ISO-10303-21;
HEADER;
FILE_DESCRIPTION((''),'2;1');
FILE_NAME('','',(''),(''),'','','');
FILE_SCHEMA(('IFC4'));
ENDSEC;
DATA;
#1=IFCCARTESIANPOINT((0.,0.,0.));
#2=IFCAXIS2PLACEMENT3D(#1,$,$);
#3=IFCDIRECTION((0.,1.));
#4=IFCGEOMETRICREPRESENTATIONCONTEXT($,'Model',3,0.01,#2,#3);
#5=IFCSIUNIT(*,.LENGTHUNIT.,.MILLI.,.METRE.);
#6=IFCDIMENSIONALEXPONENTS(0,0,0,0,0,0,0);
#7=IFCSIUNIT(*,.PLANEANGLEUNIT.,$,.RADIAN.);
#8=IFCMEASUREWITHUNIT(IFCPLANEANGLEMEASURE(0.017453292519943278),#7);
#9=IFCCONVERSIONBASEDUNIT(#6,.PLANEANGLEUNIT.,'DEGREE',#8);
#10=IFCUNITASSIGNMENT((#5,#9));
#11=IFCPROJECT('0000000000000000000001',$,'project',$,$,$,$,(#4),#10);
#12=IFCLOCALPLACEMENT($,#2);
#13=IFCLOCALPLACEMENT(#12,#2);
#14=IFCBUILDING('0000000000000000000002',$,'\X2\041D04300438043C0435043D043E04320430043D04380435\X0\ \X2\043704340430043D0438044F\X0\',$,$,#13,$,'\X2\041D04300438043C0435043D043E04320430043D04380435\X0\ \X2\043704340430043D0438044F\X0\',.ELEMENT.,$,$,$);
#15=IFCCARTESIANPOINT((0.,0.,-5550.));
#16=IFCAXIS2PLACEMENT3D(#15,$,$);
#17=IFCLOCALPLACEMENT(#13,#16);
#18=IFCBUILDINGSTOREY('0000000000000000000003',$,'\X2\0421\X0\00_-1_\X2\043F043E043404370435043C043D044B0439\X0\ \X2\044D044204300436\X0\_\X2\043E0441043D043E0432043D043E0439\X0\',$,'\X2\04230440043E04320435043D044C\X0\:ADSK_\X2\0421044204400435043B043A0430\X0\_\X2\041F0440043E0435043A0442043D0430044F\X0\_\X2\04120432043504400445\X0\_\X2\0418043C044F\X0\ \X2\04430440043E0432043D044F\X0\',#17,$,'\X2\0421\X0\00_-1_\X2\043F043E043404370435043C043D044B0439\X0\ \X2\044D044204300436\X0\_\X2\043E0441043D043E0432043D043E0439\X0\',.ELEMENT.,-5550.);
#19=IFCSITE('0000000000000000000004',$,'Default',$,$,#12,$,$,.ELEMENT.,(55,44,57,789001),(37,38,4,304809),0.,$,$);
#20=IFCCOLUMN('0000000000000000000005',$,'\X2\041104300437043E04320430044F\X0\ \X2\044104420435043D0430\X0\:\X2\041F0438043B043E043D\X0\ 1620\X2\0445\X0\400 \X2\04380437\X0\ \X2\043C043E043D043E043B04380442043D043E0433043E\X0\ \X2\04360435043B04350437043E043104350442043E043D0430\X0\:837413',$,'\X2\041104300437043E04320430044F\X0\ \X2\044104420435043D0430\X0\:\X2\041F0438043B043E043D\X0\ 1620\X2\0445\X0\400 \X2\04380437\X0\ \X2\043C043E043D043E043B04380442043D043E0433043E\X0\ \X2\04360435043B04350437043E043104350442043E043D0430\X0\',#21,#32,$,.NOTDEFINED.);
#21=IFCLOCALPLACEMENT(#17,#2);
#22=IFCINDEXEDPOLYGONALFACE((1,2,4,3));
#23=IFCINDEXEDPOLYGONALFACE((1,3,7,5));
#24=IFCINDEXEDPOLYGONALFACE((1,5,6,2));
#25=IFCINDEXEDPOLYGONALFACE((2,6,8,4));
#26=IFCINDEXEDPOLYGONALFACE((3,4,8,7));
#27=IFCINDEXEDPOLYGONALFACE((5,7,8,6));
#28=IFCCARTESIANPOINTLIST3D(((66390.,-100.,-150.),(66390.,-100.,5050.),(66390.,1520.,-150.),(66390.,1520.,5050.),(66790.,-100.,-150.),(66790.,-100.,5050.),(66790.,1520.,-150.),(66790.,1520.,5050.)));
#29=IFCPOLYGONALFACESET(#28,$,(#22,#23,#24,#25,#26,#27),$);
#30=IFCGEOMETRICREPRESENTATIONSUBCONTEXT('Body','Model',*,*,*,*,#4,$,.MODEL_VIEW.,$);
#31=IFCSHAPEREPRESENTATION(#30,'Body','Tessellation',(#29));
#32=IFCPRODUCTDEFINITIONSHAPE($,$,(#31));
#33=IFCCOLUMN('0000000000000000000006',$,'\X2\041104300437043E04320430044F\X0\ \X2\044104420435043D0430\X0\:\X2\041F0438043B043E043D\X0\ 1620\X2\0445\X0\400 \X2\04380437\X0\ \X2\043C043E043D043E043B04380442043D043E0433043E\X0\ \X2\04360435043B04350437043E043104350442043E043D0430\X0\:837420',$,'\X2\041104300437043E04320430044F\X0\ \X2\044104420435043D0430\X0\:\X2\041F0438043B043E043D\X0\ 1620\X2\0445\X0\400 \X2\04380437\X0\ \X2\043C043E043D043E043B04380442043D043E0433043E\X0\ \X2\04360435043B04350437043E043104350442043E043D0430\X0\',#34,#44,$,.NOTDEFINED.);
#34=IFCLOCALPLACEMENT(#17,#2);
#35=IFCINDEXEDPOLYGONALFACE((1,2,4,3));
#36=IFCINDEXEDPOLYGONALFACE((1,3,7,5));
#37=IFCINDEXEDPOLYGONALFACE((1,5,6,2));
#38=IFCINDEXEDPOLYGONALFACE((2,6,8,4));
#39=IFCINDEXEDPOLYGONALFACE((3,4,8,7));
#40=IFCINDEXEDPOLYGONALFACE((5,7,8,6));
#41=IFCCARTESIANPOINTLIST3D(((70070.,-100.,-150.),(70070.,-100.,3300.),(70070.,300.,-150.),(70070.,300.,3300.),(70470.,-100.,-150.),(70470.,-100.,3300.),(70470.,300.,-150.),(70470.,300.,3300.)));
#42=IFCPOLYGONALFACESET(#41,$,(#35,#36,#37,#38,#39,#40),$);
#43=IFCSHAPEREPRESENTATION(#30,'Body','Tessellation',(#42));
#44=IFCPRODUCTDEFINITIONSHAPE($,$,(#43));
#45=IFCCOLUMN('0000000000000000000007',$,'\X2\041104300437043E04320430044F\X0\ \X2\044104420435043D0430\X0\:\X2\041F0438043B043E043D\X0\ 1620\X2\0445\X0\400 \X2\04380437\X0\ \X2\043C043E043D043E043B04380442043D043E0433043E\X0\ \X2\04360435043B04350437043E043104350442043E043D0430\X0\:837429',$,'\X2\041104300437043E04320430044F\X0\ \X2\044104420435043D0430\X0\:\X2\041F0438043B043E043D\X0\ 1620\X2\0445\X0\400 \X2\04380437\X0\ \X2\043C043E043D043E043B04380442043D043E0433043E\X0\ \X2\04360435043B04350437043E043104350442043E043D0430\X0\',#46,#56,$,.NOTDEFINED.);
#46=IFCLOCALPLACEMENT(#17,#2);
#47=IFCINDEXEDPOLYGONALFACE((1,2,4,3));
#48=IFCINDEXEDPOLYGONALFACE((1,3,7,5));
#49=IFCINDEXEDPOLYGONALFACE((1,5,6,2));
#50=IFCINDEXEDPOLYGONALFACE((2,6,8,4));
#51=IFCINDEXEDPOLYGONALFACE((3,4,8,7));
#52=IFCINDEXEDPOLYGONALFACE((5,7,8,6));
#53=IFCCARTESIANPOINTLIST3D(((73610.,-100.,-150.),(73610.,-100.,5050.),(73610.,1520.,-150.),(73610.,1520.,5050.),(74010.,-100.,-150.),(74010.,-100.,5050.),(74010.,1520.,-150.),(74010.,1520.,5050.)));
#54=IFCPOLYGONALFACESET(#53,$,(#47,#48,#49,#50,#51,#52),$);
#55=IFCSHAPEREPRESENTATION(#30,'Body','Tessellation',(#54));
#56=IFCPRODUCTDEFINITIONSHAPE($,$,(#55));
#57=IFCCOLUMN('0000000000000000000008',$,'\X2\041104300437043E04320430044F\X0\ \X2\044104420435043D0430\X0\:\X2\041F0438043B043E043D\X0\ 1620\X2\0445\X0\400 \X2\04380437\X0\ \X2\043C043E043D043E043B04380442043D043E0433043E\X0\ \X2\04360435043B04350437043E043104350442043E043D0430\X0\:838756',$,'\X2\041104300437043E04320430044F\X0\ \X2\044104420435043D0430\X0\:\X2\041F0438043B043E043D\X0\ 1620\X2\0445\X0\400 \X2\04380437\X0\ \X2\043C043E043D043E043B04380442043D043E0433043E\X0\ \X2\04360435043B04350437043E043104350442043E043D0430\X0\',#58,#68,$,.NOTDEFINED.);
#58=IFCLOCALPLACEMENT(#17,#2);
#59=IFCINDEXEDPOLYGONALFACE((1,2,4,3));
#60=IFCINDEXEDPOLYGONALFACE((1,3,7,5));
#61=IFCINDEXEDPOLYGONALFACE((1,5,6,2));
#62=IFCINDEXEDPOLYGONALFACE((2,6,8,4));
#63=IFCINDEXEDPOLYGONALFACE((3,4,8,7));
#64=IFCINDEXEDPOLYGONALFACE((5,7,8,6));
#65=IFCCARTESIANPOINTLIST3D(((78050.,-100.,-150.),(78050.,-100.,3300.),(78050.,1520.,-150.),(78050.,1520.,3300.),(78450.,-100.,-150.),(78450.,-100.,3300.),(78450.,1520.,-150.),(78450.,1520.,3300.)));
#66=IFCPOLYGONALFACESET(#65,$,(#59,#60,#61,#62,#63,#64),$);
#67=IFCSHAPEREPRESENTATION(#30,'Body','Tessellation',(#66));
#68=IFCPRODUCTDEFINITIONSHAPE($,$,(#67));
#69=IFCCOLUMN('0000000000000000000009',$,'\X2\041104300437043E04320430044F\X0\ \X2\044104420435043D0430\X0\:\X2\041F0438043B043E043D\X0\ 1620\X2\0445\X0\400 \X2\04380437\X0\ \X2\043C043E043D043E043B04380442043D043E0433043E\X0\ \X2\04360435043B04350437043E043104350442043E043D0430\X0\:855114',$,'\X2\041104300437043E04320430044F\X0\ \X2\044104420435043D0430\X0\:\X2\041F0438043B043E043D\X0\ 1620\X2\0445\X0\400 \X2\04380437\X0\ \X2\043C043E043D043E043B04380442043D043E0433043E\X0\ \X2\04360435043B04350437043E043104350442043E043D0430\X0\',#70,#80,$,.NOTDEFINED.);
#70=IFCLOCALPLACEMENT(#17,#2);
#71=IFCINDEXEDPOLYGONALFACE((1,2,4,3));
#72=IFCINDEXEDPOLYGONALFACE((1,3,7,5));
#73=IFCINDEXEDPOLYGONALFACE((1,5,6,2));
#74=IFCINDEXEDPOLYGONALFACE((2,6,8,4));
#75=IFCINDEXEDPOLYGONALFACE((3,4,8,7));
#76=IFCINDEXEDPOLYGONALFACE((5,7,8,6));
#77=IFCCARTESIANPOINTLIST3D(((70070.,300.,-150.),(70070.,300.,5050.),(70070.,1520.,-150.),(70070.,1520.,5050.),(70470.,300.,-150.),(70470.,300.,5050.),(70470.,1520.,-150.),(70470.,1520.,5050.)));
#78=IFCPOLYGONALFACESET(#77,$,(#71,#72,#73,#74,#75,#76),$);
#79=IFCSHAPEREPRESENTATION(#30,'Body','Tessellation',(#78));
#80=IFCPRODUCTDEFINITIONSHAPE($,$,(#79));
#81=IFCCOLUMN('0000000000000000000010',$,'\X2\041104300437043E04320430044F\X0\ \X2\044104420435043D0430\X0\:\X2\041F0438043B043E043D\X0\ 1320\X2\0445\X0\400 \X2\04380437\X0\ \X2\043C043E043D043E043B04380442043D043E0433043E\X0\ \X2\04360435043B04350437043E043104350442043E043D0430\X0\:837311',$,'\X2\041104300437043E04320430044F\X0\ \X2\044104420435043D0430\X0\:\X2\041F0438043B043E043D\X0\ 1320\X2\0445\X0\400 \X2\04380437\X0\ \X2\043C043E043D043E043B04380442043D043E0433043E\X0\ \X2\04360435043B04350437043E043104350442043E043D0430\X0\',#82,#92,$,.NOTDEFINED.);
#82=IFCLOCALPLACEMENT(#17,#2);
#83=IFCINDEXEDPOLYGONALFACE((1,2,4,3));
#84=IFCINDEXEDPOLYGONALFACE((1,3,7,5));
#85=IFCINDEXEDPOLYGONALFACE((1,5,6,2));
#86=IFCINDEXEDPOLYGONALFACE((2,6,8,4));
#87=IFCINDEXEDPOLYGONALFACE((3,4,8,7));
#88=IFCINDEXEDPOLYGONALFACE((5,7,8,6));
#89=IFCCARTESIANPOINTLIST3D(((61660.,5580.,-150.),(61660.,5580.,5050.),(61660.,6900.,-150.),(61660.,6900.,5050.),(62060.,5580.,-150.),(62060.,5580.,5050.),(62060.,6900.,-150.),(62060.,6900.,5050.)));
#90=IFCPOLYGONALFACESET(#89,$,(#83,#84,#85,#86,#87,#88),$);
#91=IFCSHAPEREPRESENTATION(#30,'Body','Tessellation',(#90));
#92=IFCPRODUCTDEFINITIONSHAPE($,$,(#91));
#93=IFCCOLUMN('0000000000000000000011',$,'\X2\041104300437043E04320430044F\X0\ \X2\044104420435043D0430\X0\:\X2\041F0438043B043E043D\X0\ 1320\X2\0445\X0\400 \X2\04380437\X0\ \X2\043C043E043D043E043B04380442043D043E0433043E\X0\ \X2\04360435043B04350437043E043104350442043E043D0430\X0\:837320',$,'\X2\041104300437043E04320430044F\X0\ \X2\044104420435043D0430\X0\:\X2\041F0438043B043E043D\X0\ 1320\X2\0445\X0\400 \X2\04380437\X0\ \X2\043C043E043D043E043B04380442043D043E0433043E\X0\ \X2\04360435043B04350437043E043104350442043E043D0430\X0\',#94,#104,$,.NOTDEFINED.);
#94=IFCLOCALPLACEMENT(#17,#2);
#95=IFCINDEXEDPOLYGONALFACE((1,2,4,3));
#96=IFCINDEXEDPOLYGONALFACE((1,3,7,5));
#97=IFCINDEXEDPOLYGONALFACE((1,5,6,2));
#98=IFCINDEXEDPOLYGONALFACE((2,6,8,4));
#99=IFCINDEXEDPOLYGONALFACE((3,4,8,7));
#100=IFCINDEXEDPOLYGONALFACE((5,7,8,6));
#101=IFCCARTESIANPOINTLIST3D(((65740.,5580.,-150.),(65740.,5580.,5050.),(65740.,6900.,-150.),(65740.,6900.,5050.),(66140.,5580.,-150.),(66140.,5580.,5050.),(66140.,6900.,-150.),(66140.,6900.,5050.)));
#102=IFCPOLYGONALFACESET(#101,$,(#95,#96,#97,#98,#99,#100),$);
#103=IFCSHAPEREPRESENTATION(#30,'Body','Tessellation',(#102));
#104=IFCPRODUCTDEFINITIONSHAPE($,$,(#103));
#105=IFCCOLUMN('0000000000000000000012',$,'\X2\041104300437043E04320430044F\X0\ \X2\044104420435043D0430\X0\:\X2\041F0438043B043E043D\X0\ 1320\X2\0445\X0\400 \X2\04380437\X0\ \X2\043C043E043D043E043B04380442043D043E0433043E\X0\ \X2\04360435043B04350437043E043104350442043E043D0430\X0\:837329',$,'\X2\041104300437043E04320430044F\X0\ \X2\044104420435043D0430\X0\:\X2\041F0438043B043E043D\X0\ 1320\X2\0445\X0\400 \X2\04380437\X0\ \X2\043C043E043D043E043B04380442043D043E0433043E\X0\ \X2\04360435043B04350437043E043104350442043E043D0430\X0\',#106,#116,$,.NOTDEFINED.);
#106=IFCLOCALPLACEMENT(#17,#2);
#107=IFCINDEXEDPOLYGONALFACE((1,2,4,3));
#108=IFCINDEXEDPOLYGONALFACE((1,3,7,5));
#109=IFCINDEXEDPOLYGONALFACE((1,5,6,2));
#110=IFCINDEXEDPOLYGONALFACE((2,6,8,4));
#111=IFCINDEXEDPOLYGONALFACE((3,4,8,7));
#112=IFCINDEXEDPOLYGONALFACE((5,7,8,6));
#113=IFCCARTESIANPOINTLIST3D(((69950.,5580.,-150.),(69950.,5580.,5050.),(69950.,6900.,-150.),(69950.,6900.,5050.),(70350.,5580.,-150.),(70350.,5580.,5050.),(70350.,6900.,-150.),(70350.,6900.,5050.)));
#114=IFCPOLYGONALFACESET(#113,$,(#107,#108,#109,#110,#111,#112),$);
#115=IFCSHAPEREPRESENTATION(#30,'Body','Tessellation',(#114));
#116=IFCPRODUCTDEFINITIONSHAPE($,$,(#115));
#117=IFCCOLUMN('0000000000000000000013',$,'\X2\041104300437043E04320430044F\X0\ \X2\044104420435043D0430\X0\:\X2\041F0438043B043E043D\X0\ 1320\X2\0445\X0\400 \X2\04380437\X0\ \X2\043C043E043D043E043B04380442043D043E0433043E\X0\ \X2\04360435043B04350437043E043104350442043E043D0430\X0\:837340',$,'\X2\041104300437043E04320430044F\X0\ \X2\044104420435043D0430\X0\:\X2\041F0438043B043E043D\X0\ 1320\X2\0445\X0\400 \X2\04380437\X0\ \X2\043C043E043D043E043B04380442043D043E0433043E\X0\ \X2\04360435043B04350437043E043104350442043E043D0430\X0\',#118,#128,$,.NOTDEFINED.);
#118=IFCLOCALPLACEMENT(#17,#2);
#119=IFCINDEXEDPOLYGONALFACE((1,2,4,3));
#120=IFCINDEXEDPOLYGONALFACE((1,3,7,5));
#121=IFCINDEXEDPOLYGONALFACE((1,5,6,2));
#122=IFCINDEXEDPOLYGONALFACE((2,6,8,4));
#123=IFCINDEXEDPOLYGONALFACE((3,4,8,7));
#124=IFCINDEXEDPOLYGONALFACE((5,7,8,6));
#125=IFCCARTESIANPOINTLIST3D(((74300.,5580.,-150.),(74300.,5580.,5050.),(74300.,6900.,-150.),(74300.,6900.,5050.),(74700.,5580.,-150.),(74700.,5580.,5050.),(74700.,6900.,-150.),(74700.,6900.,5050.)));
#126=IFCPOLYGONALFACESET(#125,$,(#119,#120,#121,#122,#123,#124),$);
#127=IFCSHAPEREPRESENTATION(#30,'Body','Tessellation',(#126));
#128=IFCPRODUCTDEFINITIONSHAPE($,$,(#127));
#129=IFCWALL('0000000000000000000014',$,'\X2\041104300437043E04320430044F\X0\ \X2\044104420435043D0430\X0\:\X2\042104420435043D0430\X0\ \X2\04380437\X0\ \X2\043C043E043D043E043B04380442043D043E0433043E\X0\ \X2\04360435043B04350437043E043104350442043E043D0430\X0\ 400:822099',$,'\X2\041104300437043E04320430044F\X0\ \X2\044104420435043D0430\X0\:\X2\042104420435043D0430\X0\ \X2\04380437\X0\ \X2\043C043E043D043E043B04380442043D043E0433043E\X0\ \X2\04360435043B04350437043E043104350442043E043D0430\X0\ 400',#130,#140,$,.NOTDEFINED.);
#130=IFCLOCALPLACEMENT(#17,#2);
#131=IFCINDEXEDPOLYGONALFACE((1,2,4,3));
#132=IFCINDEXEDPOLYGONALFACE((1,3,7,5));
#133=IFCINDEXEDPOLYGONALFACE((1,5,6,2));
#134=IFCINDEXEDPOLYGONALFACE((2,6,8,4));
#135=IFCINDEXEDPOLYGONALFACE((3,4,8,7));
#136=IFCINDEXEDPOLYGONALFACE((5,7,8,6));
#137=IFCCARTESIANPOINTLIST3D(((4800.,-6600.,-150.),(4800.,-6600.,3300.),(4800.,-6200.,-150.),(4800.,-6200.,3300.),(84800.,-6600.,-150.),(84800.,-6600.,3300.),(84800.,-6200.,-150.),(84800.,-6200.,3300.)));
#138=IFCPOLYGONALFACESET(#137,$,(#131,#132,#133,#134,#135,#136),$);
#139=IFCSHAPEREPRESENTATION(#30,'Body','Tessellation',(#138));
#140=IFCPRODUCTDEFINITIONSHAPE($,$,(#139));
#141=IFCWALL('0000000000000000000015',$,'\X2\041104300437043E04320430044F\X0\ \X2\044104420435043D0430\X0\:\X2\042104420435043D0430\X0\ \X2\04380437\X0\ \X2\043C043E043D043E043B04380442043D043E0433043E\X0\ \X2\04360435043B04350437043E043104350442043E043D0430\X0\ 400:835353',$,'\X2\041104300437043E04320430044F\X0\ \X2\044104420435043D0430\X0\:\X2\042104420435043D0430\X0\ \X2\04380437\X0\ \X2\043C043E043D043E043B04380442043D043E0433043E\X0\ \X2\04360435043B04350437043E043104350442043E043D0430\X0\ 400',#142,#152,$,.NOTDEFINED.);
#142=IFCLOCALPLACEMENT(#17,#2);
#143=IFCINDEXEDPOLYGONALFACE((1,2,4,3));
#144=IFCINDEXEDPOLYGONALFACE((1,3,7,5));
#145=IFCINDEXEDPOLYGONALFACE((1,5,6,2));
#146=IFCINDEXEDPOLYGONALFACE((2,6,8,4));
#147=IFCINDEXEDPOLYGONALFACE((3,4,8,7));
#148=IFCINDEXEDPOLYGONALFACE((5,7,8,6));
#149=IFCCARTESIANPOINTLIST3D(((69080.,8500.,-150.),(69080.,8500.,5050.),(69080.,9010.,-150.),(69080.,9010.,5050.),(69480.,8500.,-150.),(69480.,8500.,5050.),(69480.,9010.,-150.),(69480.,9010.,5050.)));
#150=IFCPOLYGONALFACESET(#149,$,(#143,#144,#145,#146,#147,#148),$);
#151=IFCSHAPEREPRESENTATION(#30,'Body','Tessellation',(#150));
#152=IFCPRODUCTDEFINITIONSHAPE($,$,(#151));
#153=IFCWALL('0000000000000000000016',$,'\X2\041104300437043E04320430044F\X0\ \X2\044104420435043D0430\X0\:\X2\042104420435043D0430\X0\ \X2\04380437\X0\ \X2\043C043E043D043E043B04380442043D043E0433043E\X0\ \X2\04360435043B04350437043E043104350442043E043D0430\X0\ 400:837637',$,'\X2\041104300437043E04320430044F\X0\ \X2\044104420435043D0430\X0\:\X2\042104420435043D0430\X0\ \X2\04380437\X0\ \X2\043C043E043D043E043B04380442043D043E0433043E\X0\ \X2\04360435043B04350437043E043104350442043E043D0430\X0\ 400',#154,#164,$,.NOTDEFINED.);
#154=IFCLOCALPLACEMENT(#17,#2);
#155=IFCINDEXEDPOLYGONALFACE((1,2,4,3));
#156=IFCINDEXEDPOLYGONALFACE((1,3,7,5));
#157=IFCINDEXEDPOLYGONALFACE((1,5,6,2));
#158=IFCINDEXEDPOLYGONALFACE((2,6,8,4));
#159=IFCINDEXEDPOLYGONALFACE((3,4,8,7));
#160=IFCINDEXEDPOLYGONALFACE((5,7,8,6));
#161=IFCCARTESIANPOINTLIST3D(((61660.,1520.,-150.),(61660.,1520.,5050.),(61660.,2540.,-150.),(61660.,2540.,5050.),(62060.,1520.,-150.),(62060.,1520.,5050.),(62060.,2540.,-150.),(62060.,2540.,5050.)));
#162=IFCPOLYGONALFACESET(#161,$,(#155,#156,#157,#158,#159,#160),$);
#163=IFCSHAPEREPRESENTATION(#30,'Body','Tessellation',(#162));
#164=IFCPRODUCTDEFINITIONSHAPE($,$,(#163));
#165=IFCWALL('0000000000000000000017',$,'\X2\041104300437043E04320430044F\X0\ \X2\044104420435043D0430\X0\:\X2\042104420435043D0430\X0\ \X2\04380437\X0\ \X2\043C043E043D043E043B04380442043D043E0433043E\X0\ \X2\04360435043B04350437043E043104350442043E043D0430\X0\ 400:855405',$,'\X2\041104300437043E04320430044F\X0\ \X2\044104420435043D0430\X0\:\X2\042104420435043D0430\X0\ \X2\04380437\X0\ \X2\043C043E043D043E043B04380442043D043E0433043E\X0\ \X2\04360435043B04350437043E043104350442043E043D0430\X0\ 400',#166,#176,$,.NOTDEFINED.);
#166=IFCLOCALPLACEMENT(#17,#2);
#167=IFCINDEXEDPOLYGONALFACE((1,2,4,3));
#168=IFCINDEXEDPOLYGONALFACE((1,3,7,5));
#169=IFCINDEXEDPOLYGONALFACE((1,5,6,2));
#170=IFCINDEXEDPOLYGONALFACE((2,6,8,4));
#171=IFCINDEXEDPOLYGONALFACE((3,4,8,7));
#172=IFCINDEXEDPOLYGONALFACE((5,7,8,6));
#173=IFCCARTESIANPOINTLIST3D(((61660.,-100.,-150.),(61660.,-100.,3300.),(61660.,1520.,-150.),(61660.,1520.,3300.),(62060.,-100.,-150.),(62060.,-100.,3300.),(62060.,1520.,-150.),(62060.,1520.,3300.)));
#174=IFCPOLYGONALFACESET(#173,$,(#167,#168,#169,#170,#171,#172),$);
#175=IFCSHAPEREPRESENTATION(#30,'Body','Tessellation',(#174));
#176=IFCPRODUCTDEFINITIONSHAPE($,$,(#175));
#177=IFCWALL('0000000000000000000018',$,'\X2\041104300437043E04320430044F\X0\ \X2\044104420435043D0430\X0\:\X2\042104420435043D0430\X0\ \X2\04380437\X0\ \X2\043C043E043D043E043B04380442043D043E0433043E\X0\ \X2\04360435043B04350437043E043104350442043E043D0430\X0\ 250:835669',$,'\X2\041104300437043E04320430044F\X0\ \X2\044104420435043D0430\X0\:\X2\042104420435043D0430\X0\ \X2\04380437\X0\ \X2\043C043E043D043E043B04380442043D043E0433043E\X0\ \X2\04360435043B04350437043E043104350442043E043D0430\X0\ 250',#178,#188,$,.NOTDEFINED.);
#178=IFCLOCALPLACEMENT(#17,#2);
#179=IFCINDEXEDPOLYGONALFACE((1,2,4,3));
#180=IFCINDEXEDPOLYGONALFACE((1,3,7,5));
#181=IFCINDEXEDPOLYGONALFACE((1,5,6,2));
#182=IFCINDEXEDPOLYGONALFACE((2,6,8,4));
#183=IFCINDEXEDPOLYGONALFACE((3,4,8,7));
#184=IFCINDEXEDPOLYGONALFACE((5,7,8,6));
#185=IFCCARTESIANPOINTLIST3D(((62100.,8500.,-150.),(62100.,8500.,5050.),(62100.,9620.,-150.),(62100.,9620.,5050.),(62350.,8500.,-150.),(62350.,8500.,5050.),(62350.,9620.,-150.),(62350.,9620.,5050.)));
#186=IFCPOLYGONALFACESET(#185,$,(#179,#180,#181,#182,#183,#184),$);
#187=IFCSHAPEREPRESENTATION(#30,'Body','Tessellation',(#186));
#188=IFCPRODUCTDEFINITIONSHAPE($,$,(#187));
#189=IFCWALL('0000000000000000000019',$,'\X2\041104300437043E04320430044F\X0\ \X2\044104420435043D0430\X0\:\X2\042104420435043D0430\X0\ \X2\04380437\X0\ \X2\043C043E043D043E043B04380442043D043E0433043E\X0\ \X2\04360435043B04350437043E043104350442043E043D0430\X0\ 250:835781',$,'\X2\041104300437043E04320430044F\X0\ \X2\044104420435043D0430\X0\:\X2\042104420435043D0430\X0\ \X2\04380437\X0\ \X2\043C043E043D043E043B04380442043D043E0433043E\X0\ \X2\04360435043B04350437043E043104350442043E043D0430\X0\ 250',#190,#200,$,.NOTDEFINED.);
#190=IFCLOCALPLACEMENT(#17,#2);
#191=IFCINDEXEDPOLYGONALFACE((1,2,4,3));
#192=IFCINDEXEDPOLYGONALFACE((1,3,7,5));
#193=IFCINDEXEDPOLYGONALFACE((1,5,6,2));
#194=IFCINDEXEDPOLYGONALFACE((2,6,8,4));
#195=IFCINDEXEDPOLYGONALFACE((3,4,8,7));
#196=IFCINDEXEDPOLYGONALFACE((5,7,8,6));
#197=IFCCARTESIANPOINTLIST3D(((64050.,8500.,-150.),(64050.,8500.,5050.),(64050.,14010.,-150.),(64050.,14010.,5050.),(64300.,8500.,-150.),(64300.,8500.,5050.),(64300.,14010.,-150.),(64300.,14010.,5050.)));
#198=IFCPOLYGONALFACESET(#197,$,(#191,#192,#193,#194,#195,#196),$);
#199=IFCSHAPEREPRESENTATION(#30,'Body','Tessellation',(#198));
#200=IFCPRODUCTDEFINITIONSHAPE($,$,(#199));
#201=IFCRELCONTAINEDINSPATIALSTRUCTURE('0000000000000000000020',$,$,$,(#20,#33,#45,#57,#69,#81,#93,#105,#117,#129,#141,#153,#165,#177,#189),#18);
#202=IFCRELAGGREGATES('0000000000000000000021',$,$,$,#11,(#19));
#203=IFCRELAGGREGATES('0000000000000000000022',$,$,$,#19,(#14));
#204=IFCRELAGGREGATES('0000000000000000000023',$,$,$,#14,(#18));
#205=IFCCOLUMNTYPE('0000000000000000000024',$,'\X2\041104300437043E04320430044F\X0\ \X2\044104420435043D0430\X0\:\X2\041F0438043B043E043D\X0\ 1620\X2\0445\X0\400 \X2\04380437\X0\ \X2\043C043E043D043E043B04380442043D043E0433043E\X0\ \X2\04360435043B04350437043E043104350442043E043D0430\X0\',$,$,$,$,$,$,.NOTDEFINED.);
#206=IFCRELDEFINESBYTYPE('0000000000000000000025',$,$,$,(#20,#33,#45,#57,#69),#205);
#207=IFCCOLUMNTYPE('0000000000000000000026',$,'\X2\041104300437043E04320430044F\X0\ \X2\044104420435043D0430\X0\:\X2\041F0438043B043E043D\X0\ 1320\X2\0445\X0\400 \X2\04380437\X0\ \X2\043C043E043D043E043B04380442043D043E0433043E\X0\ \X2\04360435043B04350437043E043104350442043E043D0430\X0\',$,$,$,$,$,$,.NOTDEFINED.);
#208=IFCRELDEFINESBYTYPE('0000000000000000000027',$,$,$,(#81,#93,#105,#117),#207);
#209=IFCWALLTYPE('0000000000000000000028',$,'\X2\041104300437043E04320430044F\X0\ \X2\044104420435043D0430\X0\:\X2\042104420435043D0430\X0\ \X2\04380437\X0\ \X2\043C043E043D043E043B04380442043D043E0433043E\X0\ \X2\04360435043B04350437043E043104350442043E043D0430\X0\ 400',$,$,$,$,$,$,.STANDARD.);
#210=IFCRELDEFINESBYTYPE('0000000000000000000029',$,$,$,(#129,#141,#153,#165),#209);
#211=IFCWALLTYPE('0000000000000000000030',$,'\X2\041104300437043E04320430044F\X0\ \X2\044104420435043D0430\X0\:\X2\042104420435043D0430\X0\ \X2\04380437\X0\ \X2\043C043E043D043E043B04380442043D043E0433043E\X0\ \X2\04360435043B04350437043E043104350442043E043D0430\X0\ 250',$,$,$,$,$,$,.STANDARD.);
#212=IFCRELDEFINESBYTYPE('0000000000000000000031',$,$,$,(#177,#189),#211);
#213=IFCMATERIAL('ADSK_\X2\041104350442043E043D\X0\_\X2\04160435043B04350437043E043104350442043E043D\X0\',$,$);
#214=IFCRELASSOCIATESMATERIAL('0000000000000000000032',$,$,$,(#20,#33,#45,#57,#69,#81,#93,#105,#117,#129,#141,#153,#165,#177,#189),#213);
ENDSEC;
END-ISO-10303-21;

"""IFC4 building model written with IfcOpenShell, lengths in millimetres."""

from ifc_helpers import new_model, entity, si_unit, converted_unit, direction, frame, origin, place, context, subcontext, project, spatial, indexed_curve, outline, extrude, material, type_object, element, save


model = new_model("IFC4")

# Units and contexts
model_context = context("Model", 3, precision=0.01, world=origin(), true_north=direction((0.0, 1.0)))
body_context = subcontext(model_context, "Body", "Model", "MODEL_VIEW")
ifc_project = project(units=[si_unit("LENGTHUNIT", "METRE", prefix="MILLI"), converted_unit("PLANEANGLEUNIT", "DEGREE", entity("IfcPlaneAngleMeasure", 0.017453292519943278), si_unit("PLANEANGLEUNIT", "RADIAN"), dimensions=[0, 0, 0, 0, 0, 0, 0])], contexts=[model_context])

# Site, building, storey
site_placement = place(None, origin())
site = spatial("IfcSite", under=ifc_project, at=site_placement, Name="Default", CompositionType="ELEMENT", RefLatitude=(55, 44, 57, 789001), RefLongitude=(37, 38, 4, 304809), RefElevation=0.0)
building_placement = place(site_placement, origin())
building = spatial("IfcBuilding", under=site, at=building_placement, Name="Наименование здания", LongName="Наименование здания", CompositionType="ELEMENT")
storey_placement = place(building_placement, frame((0.0, 0.0, -5550.0)))
storey = spatial("IfcBuildingStorey", under=building, at=storey_placement, Name="С00_-1_подземный этаж_основной", ObjectType="Уровень:ADSK_Стрелка_Проектная_Вверх_Имя уровня", LongName="С00_-1_подземный этаж_основной", CompositionType="ELEMENT", Elevation=-5550.0)

# Columns
ifc_material_1 = material(Name="ADSK_Бетон_Железобетон")
column_type_1 = type_object("IfcColumnType", Name="Базовая стена:Пилон 1620х400 из монолитного железобетона", PredefinedType="NOTDEFINED")
column_1_placement = place(storey_placement, frame((66590.0, -100.0, -150.0), z_axis=(0.0, 0.0, 1.0), x_axis=(0.0, 1.0, 0.0)))
element("IfcColumn", 1, at=column_1_placement, inside=storey, type_object=column_type_1, material=ifc_material_1, Name="Базовая стена:Пилон 1620х400 из монолитного железобетона:837413", ObjectType="Базовая стена:Пилон 1620х400 из монолитного железобетона", PredefinedType="NOTDEFINED", context=body_context, shape_type="SweptSolid", body=[
    extrude(outline(indexed_curve([(1620.0, 200.0), (0.0, 200.0), (0.0, -200.0), (1620.0, -200.0), (1620.0, 200.0)], self_intersect=False)), origin(), (0.0, 0.0, 1.0), 5200.0),
])
column_2_placement = place(storey_placement, frame((70270.0, -100.0, -150.0), z_axis=(0.0, 0.0, 1.0), x_axis=(0.0, 1.0, 0.0)))
element("IfcColumn", 2, at=column_2_placement, inside=storey, type_object=column_type_1, material=ifc_material_1, Name="Базовая стена:Пилон 1620х400 из монолитного железобетона:837420", ObjectType="Базовая стена:Пилон 1620х400 из монолитного железобетона", PredefinedType="NOTDEFINED", context=body_context, shape_type="SweptSolid", body=[
    extrude(outline(indexed_curve([(400.0, 200.0), (0.0, 200.0), (0.0, -200.0), (400.0, -200.0), (400.0, 200.0)], self_intersect=False)), origin(), (0.0, 0.0, 1.0), 3450.0),
])
column_3_placement = place(storey_placement, frame((73810.0, -100.0, -150.0), z_axis=(0.0, 0.0, 1.0), x_axis=(0.0, 1.0, 0.0)))
element("IfcColumn", 3, at=column_3_placement, inside=storey, type_object=column_type_1, material=ifc_material_1, Name="Базовая стена:Пилон 1620х400 из монолитного железобетона:837429", ObjectType="Базовая стена:Пилон 1620х400 из монолитного железобетона", PredefinedType="NOTDEFINED", context=body_context, shape_type="SweptSolid", body=[
    extrude(outline(indexed_curve([(1620.0, 200.0), (0.0, 200.0), (0.0, -200.0), (1620.0, -200.0), (1620.0, 200.0)], self_intersect=False)), origin(), (0.0, 0.0, 1.0), 5200.0),
])
column_4_placement = place(storey_placement, frame((78250.0, -100.0, -150.0), z_axis=(0.0, 0.0, 1.0), x_axis=(0.0, 1.0, 0.0)))
element("IfcColumn", 4, at=column_4_placement, inside=storey, type_object=column_type_1, material=ifc_material_1, Name="Базовая стена:Пилон 1620х400 из монолитного железобетона:838756", ObjectType="Базовая стена:Пилон 1620х400 из монолитного железобетона", PredefinedType="NOTDEFINED", context=body_context, shape_type="SweptSolid", body=[
    extrude(outline(indexed_curve([(1620.0, 200.0), (0.0, 200.0), (0.0, -200.0), (1620.0, -200.0), (1620.0, 200.0)], self_intersect=False)), origin(), (0.0, 0.0, 1.0), 3450.0),
])
column_5_placement = place(storey_placement, frame((70270.0, 300.0, -150.0), z_axis=(0.0, 0.0, 1.0), x_axis=(0.0, 1.0, 0.0)))
element("IfcColumn", 5, at=column_5_placement, inside=storey, type_object=column_type_1, material=ifc_material_1, Name="Базовая стена:Пилон 1620х400 из монолитного железобетона:855114", ObjectType="Базовая стена:Пилон 1620х400 из монолитного железобетона", PredefinedType="NOTDEFINED", context=body_context, shape_type="SweptSolid", body=[
    extrude(outline(indexed_curve([(1220.0, 200.0), (0.0, 200.0), (0.0, -200.0), (1220.0, -200.0), (1220.0, 200.0)], self_intersect=False)), origin(), (0.0, 0.0, 1.0), 5200.0),
])
column_type_2 = type_object("IfcColumnType", Name="Базовая стена:Пилон 1320х400 из монолитного железобетона", PredefinedType="NOTDEFINED")
for number, where, z_axis, x_axis, name in (
    (6, (61860.0, 5580.0, -150.0), (0.0, 0.0, 1.0), (0.0, 1.0, 0.0), "Базовая стена:Пилон 1320х400 из монолитного железобетона:837311"),
    (7, (65940.0, 5580.0, -150.0), (0.0, 0.0, 1.0), (0.0, 1.0, 0.0), "Базовая стена:Пилон 1320х400 из монолитного железобетона:837320"),
    (8, (70150.0, 5580.0, -150.0), (0.0, 0.0, 1.0), (0.0, 1.0, 0.0), "Базовая стена:Пилон 1320х400 из монолитного железобетона:837329"),
    (9, (74500.0, 5580.0, -150.0), (0.0, 0.0, 1.0), (0.0, 1.0, 0.0), "Базовая стена:Пилон 1320х400 из монолитного железобетона:837340"),
):
    element("IfcColumn", number, at=place(storey_placement, frame(where, z_axis=z_axis, x_axis=x_axis)), inside=storey, type_object=column_type_2, material=ifc_material_1, Name=name, ObjectType="Базовая стена:Пилон 1320х400 из монолитного железобетона", PredefinedType="NOTDEFINED", context=body_context, shape_type="SweptSolid", body=[
        extrude(outline(indexed_curve([(1320.0, 200.0), (0.0, 200.0), (0.0, -200.0), (1320.0, -200.0), (1320.0, 200.0)], self_intersect=False)), origin(), (0.0, 0.0, 1.0), 5200.0),
    ])

# Walls
wall_type_1 = type_object("IfcWallType", Name="Базовая стена:Стена из монолитного железобетона 400", PredefinedType="STANDARD")
wall_1_placement = place(storey_placement, frame((84800.0, -6400.0, -150.0), z_axis=(0.0, 0.0, 1.0), x_axis=(-1.0, 0.0, 0.0)))
element("IfcWall", 10, at=wall_1_placement, inside=storey, type_object=wall_type_1, material=ifc_material_1, Name="Базовая стена:Стена из монолитного железобетона 400:822099", ObjectType="Базовая стена:Стена из монолитного железобетона 400", PredefinedType="NOTDEFINED", context=body_context, shape_type="SweptSolid", body=[
    extrude(outline(indexed_curve([(80000.0, 200.0), (0.0, 200.0), (0.0, -200.0), (80000.0, -200.0), (80000.0, 200.0)], self_intersect=False)), origin(), (0.0, 0.0, 1.0), 3450.0),
])
wall_2_placement = place(storey_placement, frame((69280.0, 8500.0, -150.0), z_axis=(0.0, 0.0, 1.0), x_axis=(0.0, 1.0, 0.0)))
element("IfcWall", 11, at=wall_2_placement, inside=storey, type_object=wall_type_1, material=ifc_material_1, Name="Базовая стена:Стена из монолитного железобетона 400:835353", ObjectType="Базовая стена:Стена из монолитного железобетона 400", PredefinedType="NOTDEFINED", context=body_context, shape_type="SweptSolid", body=[
    extrude(outline(indexed_curve([(510.0, 200.0), (0.0, 200.0), (0.0, -200.0), (510.0, -200.0), (510.0, 200.0)], self_intersect=False)), origin(), (0.0, 0.0, 1.0), 5200.0),
])
wall_3_placement = place(storey_placement, frame((61860.0, 2540.0, -150.0), z_axis=(0.0, 0.0, 1.0), x_axis=(0.0, -1.0, 0.0)))
element("IfcWall", 12, at=wall_3_placement, inside=storey, type_object=wall_type_1, material=ifc_material_1, Name="Базовая стена:Стена из монолитного железобетона 400:837637", ObjectType="Базовая стена:Стена из монолитного железобетона 400", PredefinedType="NOTDEFINED", context=body_context, shape_type="SweptSolid", body=[
    extrude(outline(indexed_curve([(1020.0, 200.0), (0.0, 200.0), (0.0, -200.0), (1020.0, -200.0), (1020.0, 200.0)], self_intersect=False)), origin(), (0.0, 0.0, 1.0), 5200.0),
])
wall_4_placement = place(storey_placement, frame((61860.0, 1520.0, -150.0), z_axis=(0.0, 0.0, 1.0), x_axis=(0.0, -1.0, 0.0)))
element("IfcWall", 13, at=wall_4_placement, inside=storey, type_object=wall_type_1, material=ifc_material_1, Name="Базовая стена:Стена из монолитного железобетона 400:855405", ObjectType="Базовая стена:Стена из монолитного железобетона 400", PredefinedType="NOTDEFINED", context=body_context, shape_type="SweptSolid", body=[
    extrude(outline(indexed_curve([(1620.0, 200.0), (0.0, 200.0), (0.0, -200.0), (1620.0, -200.0), (1620.0, 200.0)], self_intersect=False)), origin(), (0.0, 0.0, 1.0), 3450.0),
])
wall_type_2 = type_object("IfcWallType", Name="Базовая стена:Стена из монолитного железобетона 250", PredefinedType="STANDARD")
wall_5_placement = place(storey_placement, frame((62225.0, 8500.0, -150.0), z_axis=(0.0, 0.0, 1.0), x_axis=(0.0, 1.0, 0.0)))
element("IfcWall", 14, at=wall_5_placement, inside=storey, type_object=wall_type_2, material=ifc_material_1, Name="Базовая стена:Стена из монолитного железобетона 250:835669", ObjectType="Базовая стена:Стена из монолитного железобетона 250", PredefinedType="NOTDEFINED", context=body_context, shape_type="SweptSolid", body=[
    extrude(outline(indexed_curve([(1120.0, 125.0), (0.0, 125.0), (0.0, -125.0), (1120.0, -125.0), (1120.0, 125.0)], self_intersect=False)), origin(), (0.0, 0.0, 1.0), 5200.0),
])
wall_6_placement = place(storey_placement, frame((64175.0, 8500.0, -150.0), z_axis=(0.0, 0.0, 1.0), x_axis=(0.0, 1.0, 0.0)))
element("IfcWall", 15, at=wall_6_placement, inside=storey, type_object=wall_type_2, material=ifc_material_1, Name="Базовая стена:Стена из монолитного железобетона 250:835781", ObjectType="Базовая стена:Стена из монолитного железобетона 250", PredefinedType="NOTDEFINED", context=body_context, shape_type="SweptSolid", body=[
    extrude(outline(indexed_curve([(5510.0, 125.0), (0.0, 125.0), (0.0, -125.0), (5510.0, -125.0), (5510.0, 125.0)], self_intersect=False)), origin(), (0.0, 0.0, 1.0), 5200.0),
])

save(model, "model.ifc")
